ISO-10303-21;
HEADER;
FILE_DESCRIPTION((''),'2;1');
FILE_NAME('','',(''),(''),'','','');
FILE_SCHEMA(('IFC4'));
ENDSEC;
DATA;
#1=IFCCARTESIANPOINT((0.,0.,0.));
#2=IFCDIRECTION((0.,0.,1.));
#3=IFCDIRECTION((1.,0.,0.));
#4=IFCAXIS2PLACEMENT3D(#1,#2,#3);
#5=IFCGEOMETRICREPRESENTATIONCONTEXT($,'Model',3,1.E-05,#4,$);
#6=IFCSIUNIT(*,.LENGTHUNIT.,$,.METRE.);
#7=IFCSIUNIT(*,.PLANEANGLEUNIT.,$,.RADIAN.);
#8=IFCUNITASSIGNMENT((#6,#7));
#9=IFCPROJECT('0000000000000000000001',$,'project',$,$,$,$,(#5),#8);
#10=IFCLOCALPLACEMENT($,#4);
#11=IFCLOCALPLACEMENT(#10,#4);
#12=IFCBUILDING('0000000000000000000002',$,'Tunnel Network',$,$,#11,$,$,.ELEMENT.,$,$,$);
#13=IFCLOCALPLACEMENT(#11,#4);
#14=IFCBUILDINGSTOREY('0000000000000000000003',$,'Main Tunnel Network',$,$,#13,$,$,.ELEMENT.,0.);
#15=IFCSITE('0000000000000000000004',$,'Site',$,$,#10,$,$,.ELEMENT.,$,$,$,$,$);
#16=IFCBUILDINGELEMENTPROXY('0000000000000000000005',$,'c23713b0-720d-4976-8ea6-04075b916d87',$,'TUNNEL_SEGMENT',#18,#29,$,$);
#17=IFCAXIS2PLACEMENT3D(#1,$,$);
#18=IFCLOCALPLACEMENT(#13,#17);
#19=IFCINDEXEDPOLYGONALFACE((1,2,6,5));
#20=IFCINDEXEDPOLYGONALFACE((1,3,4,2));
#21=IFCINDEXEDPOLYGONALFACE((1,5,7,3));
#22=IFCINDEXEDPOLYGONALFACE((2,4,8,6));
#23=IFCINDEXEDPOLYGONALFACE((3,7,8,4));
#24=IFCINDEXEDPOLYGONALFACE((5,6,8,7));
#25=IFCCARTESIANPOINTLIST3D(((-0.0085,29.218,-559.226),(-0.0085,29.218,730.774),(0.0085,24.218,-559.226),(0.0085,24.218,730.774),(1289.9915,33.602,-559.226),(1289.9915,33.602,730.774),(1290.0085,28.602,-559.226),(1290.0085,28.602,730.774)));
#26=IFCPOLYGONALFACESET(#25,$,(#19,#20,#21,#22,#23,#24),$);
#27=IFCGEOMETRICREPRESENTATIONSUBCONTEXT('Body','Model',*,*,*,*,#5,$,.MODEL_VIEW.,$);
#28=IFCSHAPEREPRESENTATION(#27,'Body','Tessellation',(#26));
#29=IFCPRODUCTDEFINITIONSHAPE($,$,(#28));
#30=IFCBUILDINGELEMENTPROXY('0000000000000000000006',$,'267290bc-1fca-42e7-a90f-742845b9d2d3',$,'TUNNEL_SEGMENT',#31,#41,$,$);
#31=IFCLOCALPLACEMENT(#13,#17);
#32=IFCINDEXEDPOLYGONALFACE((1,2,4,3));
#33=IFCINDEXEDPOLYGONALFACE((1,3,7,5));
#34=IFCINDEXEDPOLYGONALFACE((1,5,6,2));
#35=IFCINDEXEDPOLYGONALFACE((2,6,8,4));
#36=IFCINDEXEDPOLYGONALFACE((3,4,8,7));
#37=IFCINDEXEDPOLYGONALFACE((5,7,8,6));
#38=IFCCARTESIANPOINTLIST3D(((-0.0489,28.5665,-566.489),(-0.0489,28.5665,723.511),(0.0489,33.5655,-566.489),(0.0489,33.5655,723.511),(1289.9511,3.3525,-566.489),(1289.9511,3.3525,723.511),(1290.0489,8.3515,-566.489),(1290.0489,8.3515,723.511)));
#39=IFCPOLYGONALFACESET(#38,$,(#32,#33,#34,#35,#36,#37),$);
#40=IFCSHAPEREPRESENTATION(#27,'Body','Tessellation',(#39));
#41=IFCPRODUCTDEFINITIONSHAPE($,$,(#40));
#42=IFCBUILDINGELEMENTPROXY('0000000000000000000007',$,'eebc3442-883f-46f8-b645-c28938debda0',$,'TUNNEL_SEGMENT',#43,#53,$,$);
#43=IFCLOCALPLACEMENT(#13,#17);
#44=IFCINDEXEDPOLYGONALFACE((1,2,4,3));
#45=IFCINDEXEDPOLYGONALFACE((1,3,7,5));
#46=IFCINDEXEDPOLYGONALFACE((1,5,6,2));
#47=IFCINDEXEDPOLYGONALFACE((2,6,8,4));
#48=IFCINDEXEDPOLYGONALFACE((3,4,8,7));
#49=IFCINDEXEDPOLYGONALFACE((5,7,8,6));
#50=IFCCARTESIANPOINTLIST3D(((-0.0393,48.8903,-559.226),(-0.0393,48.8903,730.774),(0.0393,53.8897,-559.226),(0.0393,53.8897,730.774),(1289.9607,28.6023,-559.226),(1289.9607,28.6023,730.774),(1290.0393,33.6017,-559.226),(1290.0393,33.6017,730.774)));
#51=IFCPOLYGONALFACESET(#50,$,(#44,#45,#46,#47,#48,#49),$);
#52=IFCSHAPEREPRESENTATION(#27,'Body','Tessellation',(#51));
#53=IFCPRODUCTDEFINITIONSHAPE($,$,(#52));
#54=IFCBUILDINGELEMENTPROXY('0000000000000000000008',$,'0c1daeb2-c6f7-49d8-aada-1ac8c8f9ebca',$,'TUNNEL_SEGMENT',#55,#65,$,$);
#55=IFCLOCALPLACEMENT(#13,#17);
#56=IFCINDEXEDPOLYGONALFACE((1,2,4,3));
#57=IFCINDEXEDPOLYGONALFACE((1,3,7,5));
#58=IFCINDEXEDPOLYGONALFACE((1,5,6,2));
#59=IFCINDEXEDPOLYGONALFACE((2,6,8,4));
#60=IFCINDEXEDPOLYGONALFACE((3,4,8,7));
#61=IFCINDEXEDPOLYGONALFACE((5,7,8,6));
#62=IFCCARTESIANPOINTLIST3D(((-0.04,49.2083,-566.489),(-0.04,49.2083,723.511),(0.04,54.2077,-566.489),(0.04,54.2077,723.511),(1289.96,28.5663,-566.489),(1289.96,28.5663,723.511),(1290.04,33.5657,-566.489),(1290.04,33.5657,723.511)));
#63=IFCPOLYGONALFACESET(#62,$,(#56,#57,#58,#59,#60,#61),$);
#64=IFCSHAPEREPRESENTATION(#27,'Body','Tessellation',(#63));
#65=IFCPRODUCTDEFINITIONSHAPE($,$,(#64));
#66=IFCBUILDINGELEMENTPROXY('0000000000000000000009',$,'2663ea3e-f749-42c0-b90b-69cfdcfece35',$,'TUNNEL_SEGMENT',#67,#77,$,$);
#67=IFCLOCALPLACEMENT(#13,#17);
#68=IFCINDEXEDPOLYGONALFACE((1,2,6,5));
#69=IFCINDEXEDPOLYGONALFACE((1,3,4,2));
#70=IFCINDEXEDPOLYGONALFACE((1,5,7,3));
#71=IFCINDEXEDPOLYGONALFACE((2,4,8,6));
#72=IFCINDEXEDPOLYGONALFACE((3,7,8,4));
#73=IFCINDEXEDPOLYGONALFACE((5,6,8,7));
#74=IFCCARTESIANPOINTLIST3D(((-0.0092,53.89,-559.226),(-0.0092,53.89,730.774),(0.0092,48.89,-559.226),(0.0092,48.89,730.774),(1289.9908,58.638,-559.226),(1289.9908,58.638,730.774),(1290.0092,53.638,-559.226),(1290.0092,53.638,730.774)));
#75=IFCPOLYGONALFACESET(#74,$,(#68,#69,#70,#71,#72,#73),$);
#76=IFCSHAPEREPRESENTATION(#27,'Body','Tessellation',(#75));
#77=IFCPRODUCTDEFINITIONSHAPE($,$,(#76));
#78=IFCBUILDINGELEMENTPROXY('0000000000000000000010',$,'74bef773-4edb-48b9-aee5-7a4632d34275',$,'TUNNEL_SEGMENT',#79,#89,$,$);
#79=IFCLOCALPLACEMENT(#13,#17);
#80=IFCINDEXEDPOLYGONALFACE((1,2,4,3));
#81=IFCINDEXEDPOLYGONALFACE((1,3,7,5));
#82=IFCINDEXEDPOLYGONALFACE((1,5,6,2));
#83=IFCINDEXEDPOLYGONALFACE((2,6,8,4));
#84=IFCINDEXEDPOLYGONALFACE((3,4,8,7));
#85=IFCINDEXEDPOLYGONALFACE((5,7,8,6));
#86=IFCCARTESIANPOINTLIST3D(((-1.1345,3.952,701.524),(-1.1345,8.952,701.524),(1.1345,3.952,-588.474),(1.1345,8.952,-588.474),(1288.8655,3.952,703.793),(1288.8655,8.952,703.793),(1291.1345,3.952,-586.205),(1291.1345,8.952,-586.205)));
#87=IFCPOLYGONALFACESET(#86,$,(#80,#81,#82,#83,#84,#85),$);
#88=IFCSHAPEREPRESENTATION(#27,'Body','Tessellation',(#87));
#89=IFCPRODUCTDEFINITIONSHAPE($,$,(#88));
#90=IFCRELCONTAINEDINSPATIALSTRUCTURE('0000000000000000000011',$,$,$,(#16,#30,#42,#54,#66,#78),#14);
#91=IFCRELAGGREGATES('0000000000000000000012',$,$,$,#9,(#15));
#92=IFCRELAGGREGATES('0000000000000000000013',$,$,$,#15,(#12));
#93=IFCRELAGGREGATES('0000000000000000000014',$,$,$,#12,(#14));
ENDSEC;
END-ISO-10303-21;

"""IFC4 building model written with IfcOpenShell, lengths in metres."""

from ifc_helpers import new_model, si_unit, frame, origin_with_axes, origin_2d_with_axis, place, context, subcontext, project, spatial, rectangle, extrude, element, save


model = new_model("IFC4")

# Units and contexts
model_context = context("Model", 3, precision=1e-05, world=origin_with_axes())
body_context = subcontext(model_context, "Body", "Model", "MODEL_VIEW")
ifc_project = project(units=[si_unit("LENGTHUNIT", "METRE"), si_unit("PLANEANGLEUNIT", "RADIAN")], contexts=[model_context])

# Site, building, storey
site_placement = place(None, origin_with_axes())
site = spatial("IfcSite", under=ifc_project, at=site_placement, Name="Site", CompositionType="ELEMENT")
building_placement = place(site_placement, origin_with_axes())
building = spatial("IfcBuilding", under=site, at=building_placement, Name="Tunnel Network", CompositionType="ELEMENT")
storey_placement = place(building_placement, origin_with_axes())
storey = spatial("IfcBuildingStorey", under=building, at=storey_placement, Name="Main Tunnel Network", CompositionType="ELEMENT", Elevation=0.0)

# Building element proxies
proxy_1_placement = place(storey_placement, frame((0.0, 26.718, 85.774), z_axis=(0.999994, 0.003398, 0.0), x_axis=(0.0, 0.0, 1.0)))
element("IfcBuildingElementProxy", 1, at=proxy_1_placement, inside=storey, Name="c23713b0-720d-4976-8ea6-04075b916d87", ObjectType="TUNNEL_SEGMENT", context=body_context, shape_type="SweptSolid", body=[
    extrude(rectangle(XDim=1290.0, YDim=5.0, at=origin_2d_with_axis()), origin_with_axes(), (0.0, 0.0, 1.0), 1290.0074),
])
proxy_2_placement = place(storey_placement, frame((0.0, 31.066, 78.511), z_axis=(0.999809, -0.019542, 0.0), x_axis=(0.0, 0.0, 1.0)))
element("IfcBuildingElementProxy", 2, at=proxy_2_placement, inside=storey, Name="267290bc-1fca-42e7-a90f-742845b9d2d3", ObjectType="TUNNEL_SEGMENT", context=body_context, shape_type="SweptSolid", body=[
    extrude(rectangle(XDim=1290.0, YDim=5.0, at=origin_2d_with_axis()), origin_with_axes(), (0.0, 0.0, 1.0), 1290.2464),
])
proxy_3_placement = place(storey_placement, frame((0.0, 51.39, 85.774), z_axis=(0.999876, -0.015725, 0.0), x_axis=(0.0, 0.0, 1.0)))
element("IfcBuildingElementProxy", 3, at=proxy_3_placement, inside=storey, Name="eebc3442-883f-46f8-b645-c28938debda0", ObjectType="TUNNEL_SEGMENT", context=body_context, shape_type="SweptSolid", body=[
    extrude(rectangle(XDim=1290.0, YDim=5.0, at=origin_2d_with_axis()), origin_with_axes(), (0.0, 0.0, 1.0), 1290.1595),
])
proxy_4_placement = place(storey_placement, frame((0.0, 51.708, 78.511), z_axis=(0.999872, -0.016, 0.0), x_axis=(0.0, 0.0, 1.0)))
element("IfcBuildingElementProxy", 4, at=proxy_4_placement, inside=storey, Name="0c1daeb2-c6f7-49d8-aada-1ac8c8f9ebca", ObjectType="TUNNEL_SEGMENT", context=body_context, shape_type="SweptSolid", body=[
    extrude(rectangle(XDim=1290.0, YDim=5.0, at=origin_2d_with_axis()), origin_with_axes(), (0.0, 0.0, 1.0), 1290.1651),
])
proxy_5_placement = place(storey_placement, frame((0.0, 51.39, 85.774), z_axis=(0.999993, 0.003681, 0.0), x_axis=(0.0, 0.0, 1.0)))
element("IfcBuildingElementProxy", 5, at=proxy_5_placement, inside=storey, Name="2663ea3e-f749-42c0-b90b-69cfdcfece35", ObjectType="TUNNEL_SEGMENT", context=body_context, shape_type="SweptSolid", body=[
    extrude(rectangle(XDim=1290.0, YDim=5.0, at=origin_2d_with_axis()), origin_with_axes(), (0.0, 0.0, 1.0), 1290.0087),
])
proxy_6_placement = place(storey_placement, frame((0.0, 6.452, 56.525), z_axis=(0.999998, 0.0, 0.001759), x_axis=(-0.001759, 0.0, 0.999998)))
element("IfcBuildingElementProxy", 6, at=proxy_6_placement, inside=storey, Name="74bef773-4edb-48b9-aee5-7a4632d34275", ObjectType="TUNNEL_SEGMENT", context=body_context, shape_type="SweptSolid", body=[
    extrude(rectangle(XDim=1290.0, YDim=5.0, at=origin_2d_with_axis()), origin_with_axes(), (0.0, 0.0, 1.0), 1290.002),
])

save(model, "model.ifc")
